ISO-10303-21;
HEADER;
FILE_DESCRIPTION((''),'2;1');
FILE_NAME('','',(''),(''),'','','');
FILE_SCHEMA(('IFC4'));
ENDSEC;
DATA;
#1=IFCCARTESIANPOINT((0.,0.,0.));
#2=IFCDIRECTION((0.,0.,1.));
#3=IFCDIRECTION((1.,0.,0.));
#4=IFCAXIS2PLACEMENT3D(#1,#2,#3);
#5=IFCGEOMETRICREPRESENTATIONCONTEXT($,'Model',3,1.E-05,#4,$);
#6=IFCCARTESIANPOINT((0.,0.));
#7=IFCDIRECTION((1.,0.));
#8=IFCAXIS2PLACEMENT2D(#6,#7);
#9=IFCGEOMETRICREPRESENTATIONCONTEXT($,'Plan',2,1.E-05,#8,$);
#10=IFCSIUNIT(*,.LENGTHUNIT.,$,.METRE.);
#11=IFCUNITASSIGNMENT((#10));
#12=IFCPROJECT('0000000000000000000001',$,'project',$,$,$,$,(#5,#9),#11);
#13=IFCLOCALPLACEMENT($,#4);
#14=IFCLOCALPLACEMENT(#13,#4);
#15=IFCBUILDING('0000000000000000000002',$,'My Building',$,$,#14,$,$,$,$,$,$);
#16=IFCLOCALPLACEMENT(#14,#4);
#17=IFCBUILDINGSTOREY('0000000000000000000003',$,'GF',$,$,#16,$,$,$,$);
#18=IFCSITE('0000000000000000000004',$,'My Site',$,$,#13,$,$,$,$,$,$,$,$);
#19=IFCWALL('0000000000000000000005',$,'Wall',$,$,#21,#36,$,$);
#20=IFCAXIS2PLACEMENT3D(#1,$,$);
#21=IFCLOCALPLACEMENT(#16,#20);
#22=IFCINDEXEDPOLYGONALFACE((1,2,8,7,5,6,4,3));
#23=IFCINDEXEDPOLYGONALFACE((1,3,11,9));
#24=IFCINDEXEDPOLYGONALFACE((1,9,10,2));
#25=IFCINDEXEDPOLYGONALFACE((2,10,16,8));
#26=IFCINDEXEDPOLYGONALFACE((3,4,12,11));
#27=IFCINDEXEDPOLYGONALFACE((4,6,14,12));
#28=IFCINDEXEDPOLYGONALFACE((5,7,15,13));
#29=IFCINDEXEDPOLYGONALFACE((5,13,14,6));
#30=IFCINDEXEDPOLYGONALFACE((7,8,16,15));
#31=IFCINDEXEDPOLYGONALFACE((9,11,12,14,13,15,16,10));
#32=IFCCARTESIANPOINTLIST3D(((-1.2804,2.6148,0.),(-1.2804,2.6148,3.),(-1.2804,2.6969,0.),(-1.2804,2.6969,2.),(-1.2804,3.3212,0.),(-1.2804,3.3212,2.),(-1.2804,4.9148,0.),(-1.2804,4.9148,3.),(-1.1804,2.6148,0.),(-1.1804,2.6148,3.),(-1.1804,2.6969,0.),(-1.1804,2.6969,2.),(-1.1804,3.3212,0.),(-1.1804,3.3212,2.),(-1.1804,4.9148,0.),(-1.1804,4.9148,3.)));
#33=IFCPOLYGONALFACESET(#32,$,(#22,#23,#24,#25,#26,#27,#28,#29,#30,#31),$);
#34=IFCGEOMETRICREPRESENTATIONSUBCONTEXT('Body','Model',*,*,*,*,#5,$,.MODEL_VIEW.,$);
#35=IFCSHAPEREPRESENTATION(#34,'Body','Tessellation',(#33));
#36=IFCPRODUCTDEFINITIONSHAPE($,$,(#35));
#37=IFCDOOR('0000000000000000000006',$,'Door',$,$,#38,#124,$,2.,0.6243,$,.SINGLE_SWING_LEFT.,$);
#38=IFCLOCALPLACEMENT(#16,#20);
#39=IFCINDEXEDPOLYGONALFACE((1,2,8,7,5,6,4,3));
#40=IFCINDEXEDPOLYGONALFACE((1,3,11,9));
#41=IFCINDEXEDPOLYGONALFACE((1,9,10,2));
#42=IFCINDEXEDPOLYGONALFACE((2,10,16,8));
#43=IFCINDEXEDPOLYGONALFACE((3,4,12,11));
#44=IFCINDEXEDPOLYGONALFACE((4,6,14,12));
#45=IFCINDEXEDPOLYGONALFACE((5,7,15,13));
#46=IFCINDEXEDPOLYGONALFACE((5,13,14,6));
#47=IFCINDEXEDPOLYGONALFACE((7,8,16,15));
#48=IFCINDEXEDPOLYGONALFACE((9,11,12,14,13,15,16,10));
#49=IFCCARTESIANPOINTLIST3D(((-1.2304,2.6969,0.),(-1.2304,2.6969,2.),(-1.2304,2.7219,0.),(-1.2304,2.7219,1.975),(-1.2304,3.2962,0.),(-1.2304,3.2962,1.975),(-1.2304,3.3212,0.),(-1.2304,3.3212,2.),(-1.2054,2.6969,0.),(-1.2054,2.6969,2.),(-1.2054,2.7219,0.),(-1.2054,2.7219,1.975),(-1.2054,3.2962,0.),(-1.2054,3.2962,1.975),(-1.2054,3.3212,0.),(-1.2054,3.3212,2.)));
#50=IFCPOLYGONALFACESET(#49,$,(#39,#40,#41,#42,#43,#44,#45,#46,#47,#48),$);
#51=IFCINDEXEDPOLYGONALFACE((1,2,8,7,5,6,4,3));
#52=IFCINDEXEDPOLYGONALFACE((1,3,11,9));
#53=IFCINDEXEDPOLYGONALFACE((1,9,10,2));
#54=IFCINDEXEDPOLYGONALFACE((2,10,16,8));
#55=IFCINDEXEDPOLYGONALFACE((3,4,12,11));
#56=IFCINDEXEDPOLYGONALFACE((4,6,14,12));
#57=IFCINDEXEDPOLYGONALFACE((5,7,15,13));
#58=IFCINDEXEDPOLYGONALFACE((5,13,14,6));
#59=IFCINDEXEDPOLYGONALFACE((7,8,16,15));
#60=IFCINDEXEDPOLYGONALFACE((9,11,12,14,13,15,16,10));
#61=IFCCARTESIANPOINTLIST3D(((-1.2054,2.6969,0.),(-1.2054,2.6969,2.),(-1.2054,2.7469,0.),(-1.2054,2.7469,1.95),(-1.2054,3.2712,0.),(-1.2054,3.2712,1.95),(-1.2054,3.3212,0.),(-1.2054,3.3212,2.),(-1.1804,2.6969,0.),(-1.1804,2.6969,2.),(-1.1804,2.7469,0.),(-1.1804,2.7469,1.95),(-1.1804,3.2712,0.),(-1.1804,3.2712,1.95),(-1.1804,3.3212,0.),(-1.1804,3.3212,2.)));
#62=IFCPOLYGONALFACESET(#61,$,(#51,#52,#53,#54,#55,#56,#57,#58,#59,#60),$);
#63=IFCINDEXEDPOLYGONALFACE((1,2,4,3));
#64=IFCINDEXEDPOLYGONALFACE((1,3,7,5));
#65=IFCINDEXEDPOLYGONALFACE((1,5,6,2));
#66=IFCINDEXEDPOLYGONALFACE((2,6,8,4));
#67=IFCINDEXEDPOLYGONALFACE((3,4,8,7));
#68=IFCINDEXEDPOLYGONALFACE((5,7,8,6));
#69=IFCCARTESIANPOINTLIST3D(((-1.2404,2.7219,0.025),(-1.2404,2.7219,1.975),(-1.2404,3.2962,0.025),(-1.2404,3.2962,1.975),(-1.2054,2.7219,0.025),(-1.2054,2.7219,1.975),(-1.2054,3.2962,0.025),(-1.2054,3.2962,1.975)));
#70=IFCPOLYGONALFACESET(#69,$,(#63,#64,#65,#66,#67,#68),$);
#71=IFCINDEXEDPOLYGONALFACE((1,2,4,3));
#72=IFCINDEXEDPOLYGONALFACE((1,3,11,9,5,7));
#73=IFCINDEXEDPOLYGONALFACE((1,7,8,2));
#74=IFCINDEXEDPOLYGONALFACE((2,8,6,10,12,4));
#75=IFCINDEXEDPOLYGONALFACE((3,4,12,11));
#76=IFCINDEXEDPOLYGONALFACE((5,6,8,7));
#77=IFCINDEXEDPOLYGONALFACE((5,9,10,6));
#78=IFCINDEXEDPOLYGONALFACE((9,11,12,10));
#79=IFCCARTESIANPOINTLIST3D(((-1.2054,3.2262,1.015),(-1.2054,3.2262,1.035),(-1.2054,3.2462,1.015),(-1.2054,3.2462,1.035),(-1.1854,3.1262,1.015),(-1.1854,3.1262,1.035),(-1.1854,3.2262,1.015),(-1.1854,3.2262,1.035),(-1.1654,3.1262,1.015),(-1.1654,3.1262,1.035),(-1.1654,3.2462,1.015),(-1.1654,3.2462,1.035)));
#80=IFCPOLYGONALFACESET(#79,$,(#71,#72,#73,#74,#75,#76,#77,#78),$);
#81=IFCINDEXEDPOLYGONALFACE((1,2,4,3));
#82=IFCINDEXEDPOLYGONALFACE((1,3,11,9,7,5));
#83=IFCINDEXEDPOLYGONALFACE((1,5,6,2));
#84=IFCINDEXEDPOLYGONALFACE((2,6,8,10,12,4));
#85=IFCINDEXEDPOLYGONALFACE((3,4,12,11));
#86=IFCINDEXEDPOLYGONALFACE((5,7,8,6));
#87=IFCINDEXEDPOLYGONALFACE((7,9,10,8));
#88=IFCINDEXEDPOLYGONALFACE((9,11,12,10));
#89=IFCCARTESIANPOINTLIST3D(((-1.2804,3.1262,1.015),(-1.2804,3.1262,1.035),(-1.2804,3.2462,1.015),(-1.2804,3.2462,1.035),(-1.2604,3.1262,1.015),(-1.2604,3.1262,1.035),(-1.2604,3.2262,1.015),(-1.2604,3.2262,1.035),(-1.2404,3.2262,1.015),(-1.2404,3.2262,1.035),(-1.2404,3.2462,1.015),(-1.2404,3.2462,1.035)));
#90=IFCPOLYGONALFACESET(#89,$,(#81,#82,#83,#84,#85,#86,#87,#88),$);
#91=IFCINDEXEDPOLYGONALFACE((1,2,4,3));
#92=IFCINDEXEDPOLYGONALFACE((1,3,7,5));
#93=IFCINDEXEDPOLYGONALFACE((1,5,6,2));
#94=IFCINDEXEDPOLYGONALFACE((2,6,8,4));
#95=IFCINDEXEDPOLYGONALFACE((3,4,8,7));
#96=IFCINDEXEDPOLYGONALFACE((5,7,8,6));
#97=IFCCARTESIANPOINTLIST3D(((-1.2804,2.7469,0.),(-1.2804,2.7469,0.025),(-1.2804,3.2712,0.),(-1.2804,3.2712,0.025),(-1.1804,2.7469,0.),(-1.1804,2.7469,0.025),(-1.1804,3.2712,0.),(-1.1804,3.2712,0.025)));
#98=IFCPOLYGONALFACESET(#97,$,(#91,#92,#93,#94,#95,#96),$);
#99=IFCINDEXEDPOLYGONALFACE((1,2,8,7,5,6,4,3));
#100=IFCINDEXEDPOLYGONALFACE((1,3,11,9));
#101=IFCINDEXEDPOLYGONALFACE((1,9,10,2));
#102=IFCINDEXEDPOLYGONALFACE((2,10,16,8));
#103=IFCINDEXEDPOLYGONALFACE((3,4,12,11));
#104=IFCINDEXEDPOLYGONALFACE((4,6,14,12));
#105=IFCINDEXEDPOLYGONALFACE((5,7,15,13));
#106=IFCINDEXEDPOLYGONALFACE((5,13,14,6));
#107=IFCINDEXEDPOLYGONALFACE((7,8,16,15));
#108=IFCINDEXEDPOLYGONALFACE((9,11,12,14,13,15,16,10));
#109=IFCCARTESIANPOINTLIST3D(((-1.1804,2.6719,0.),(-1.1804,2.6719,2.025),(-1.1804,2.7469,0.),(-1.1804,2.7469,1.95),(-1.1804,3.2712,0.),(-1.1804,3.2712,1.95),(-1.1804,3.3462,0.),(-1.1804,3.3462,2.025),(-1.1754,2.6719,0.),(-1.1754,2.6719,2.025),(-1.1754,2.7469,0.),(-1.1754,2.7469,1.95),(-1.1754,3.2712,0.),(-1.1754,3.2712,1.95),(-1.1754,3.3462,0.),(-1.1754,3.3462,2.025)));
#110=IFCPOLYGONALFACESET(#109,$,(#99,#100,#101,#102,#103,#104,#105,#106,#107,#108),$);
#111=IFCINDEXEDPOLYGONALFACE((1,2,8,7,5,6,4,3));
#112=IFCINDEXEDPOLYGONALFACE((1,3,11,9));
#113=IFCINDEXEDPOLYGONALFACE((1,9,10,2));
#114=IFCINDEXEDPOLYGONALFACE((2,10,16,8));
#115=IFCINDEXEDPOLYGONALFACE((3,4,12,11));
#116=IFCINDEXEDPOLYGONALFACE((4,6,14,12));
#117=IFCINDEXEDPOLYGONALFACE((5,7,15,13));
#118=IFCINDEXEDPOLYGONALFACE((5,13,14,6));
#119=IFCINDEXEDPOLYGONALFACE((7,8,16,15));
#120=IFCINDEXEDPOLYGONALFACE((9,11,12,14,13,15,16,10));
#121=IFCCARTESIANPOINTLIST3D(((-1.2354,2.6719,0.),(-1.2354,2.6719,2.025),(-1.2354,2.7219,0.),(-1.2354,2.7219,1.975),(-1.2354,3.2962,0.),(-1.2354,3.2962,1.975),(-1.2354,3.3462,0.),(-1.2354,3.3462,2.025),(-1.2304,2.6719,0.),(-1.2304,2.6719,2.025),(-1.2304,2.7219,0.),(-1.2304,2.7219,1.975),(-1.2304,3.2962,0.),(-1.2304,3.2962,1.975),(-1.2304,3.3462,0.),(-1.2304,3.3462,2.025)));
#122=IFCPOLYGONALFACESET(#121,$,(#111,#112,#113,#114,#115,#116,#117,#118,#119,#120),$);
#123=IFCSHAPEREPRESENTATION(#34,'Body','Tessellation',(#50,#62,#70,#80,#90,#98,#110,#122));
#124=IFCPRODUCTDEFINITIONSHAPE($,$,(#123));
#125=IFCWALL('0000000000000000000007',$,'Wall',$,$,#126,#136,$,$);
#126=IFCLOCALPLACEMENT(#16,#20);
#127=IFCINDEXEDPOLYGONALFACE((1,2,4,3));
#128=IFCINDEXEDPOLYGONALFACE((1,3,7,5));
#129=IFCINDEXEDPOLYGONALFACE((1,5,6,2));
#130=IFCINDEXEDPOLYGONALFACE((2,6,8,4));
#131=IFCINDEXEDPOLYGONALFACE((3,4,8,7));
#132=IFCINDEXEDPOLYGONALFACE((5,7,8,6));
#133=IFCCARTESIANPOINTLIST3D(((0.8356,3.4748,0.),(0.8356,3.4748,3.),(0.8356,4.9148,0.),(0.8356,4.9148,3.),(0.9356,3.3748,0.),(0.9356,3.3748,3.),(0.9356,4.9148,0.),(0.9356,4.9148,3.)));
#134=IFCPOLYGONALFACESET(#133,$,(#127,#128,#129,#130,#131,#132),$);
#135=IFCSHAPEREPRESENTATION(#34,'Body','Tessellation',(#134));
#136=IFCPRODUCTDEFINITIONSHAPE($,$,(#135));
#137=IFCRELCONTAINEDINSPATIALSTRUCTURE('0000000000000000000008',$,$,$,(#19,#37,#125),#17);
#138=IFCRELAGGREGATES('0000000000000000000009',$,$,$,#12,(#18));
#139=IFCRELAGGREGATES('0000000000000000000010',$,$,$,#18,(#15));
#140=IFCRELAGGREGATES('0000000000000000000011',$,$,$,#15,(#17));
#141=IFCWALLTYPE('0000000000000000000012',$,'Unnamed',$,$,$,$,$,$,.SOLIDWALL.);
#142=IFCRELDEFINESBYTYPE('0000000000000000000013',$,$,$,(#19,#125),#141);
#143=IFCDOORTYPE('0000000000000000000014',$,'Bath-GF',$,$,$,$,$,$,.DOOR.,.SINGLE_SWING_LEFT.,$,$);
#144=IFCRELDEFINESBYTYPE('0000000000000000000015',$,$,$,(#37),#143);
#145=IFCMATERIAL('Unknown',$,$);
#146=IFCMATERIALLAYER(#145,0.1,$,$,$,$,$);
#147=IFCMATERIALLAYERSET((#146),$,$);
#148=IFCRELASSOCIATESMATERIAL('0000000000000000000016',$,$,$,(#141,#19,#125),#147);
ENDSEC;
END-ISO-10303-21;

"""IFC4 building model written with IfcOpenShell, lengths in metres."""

from ifc_helpers import new_model, entity, si_unit, frame, origin_with_axes, origin_2d_with_axis, place, context, subcontext, project, spatial, line, indexed_curve, outline, extrude, shape, source, transform, mapped, material, layer, layer_set, layer_usage, type_object, type_shapes, element, fill, save


model = new_model("IFC4")

# Units and contexts
model_context = context("Model", 3, precision=1e-05, world=origin_with_axes())
plan_context = context("Plan", 2, precision=1e-05, world=origin_2d_with_axis())
body_context_1 = subcontext(model_context, "Body", "Model", "MODEL_VIEW")
body_context_2 = subcontext(plan_context, "Body", "Plan", "PLAN_VIEW")
ifc_project = project(units=[si_unit("LENGTHUNIT", "METRE")], contexts=[model_context, plan_context])

# Site, building, storey
site_placement = place(None, origin_with_axes())
site = spatial("IfcSite", under=ifc_project, at=site_placement, Name="My Site")
building_placement = place(site_placement, origin_with_axes())
building = spatial("IfcBuilding", under=site, at=building_placement, Name="My Building")
storey_placement = place(building_placement, origin_with_axes())
storey = spatial("IfcBuildingStorey", under=building, at=storey_placement, Name="GF")

# Shared definitions
ifc_material = material(Name="Unknown")

# Shared definitions
ifc_layer_1 = layer(ifc_material, 0.1)
ifc_layer_set_1 = layer_set([ifc_layer_1])
wall_type = type_object("IfcWallType", Name="Unnamed", PredefinedType="SOLIDWALL", material=ifc_layer_set_1)

# Wall, opening, door
ifc_layer_usage_1 = layer_usage(ifc_layer_set_1, "AXIS2", "POSITIVE", 0.0)
wall_1_placement = place(storey_placement, frame((-1.1804, 2.6148, 0.0), z_axis=(0.0, 0.0, 1.0), x_axis=(0.0, 1.0, 0.0)))
wall_1 = element("IfcWall", 1, at=wall_1_placement, inside=storey, type_object=wall_type, material=ifc_layer_usage_1, Name="Wall", context=body_context_1, shape_type="SweptSolid", body=[
    extrude(outline(indexed_curve([(0.0, 0.0), (0.0, 0.1), (2.3, 0.1), (2.3, 0.0)], segments=[line(1, 2, 3, 4, 1)])), origin_with_axes(), (0.0, 0.0, 1.0), 3.0),
])
shared_shape_1 = source(origin_with_axes(), body_context_1, "Body", "SweptSolid", [
    extrude(outline(indexed_curve([(0.0, 0.0), (0.6243, 0.0), (0.6243, 2.0), (0.0, 2.0)], segments=[line(1, 2, 3, 4, 1)])), frame((0.0, -0.6, 0.0), z_axis=(0.0, -1.0, 0.0), x_axis=(1.0, 0.0, 0.0)), (0.0, 0.0, -1.0), 1.2),
])
opening_1_placement = place(wall_1_placement, frame((0.082, 0.0, 0.0), z_axis=(0.0, 0.0, 1.0), x_axis=(1.0, 0.0, 0.0)))
opening_1 = element("IfcOpeningElement", 2, at=opening_1_placement, cuts=wall_1, PredefinedType="OPENING", context=body_context_1, shape_type="MappedRepresentation", body=[
    mapped(shared_shape_1, transform((0.0, 0.0, 0.0), x_axis=(1.0, 0.0, 0.0), y_axis=(0.0, 1.0, 0.0), z_axis=(0.0, 0.0, 1.0), scale=1.0)),
])
door_type_1 = type_object("IfcDoorType", Name="Bath-GF", OperationType="SINGLE_SWING_LEFT", PredefinedType="DOOR")
shared_shape_2 = source(origin_with_axes(), body_context_1, "Body", "SweptSolid", [
    extrude(outline(indexed_curve([(0.0, 0.0), (0.0, 2.0), (0.6243, 2.0), (0.6243, 0.0), (0.5993, 0.0), (0.5993, 1.975), (0.025, 1.975), (0.025, 0.0)], segments=[line(1, 2, 3, 4, 5, 6, 7, 8, 1)])), frame((0.0, 0.025, 0.0), z_axis=(0.0, -1.0, 0.0), x_axis=(1.0, 0.0, 0.0)), (0.0, 0.0, -1.0), 0.025),
    extrude(outline(indexed_curve([(0.0, 0.0), (0.0, 2.0), (0.6243, 2.0), (0.6243, 0.0), (0.5743, 0.0), (0.5743, 1.95), (0.05, 1.95), (0.05, 0.0)], segments=[line(1, 2, 3, 4, 5, 6, 7, 8, 1)])), frame((0.0, 0.0, 0.0), z_axis=(0.0, -1.0, 0.0), x_axis=(1.0, 0.0, 0.0)), (0.0, 0.0, -1.0), 0.025),
    extrude(outline(indexed_curve([(0.0, 0.0), (0.5743, 0.0), (0.5743, 0.035), (0.0, 0.035)], segments=[line(1, 2, 3, 4, 1)])), frame((0.025, 0.025, 0.025), z_axis=(0.0, 0.0, 1.0), x_axis=(1.0, 0.0, 0.0)), (0.0, 0.0, 1.0), 1.95),
    extrude(outline(indexed_curve([(0.0, 0.0), (0.0, -0.04), (-0.12, -0.04), (-0.12, -0.02), (-0.02, -0.02), (-0.02, 0.0)], segments=[line(1, 2, 3, 4, 5, 6, 1)])), frame((0.5493, 0.025, 1.015), z_axis=(0.0, 0.0, 1.0), x_axis=(1.0, 0.0, 0.0)), (0.0, 0.0, 1.0), 0.02),
    extrude(outline(indexed_curve([(0.0, 0.0), (0.0, 0.04), (-0.12, 0.04), (-0.12, 0.02), (-0.02, 0.02), (-0.02, 0.0)], segments=[line(1, 2, 3, 4, 5, 6, 1)])), frame((0.5493, 0.06, 1.015), z_axis=(0.0, 0.0, 1.0), x_axis=(1.0, 0.0, 0.0)), (0.0, 0.0, 1.0), 0.02),
    extrude(outline(indexed_curve([(0.0, 0.0), (0.5243, 0.0), (0.5243, 0.1), (0.0, 0.1)], segments=[line(1, 2, 3, 4, 1)])), frame((0.05, 0.0, 0.0), z_axis=(0.0, 0.0, 1.0), x_axis=(1.0, 0.0, 0.0)), (0.0, 0.0, 1.0), 0.025),
    extrude(outline(indexed_curve([(0.0, 0.0), (0.0, 2.025), (0.6743, 2.025), (0.6743, 0.0), (0.5993, 0.0), (0.5993, 1.95), (0.075, 1.95), (0.075, 0.0)], segments=[line(1, 2, 3, 4, 5, 6, 7, 8, 1)])), frame((-0.025, -0.005, 0.0), z_axis=(0.0, -1.0, 0.0), x_axis=(1.0, 0.0, 0.0)), (0.0, 0.0, -1.0), 0.005),
    extrude(outline(indexed_curve([(0.0, 0.0), (0.0, 2.025), (0.6743, 2.025), (0.6743, 0.0), (0.6243, 0.0), (0.6243, 1.975), (0.05, 1.975), (0.05, 0.0)], segments=[line(1, 2, 3, 4, 5, 6, 7, 8, 1)])), frame((-0.025, 0.05, 0.0), z_axis=(0.0, -1.0, 0.0), x_axis=(1.0, 0.0, 0.0)), (0.0, 0.0, -1.0), 0.005),
])
shared_shape_3 = source(origin_with_axes(), body_context_2, "Body", "Curve2D", [
    entity("IfcIndexedPolyCurve", entity("IfcCartesianPointList2D", [[0.0, 0.0], [0.0, 0.05], [0.025, 0.05], [0.025, 0.025], [0.05, 0.025], [0.05, 0.0]]), [entity("IfcLineIndex", [1, 2, 3, 4, 5, 6, 1])]),
    entity("IfcIndexedPolyCurve", entity("IfcCartesianPointList2D", [[0.6243, 0.0], [0.6243, 0.05], [0.5993, 0.05], [0.5993, 0.025], [0.5743, 0.025], [0.5743, 0.0]]), [entity("IfcLineIndex", [1, 2, 3, 4, 5, 6, 1])]),
    entity("IfcTrimmedCurve", entity("IfcEllipse", entity("IfcAxis2Placement2D", entity("IfcCartesianPoint", [0.06, 0.05]), entity("IfcDirection", [1.0, 0.0])), 0.5393, 0.5743), [entity("IfcCartesianPoint", [0.5993, 0.05])], [entity("IfcCartesianPoint", [0.06, 0.6243])], True, "CARTESIAN"),
    entity("IfcIndexedPolyCurve", entity("IfcCartesianPointList2D", [[0.025, 0.05], [0.06, 0.05], [0.06, 0.6243], [0.025, 0.6243]]), [entity("IfcLineIndex", [1, 2, 3, 4, 1])]),
])
type_shapes(door_type_1, [shared_shape_2, shared_shape_3])
door_1_placement = place(opening_1_placement, frame((0.0, 0.0, 0.0), z_axis=(0.0, 0.0, 1.0), x_axis=(1.0, 0.0, 0.0)))
door_1 = element("IfcDoor", 3, at=door_1_placement, inside=storey, type_object=door_type_1, Name="Door", OperationType="SINGLE_SWING_LEFT", OverallHeight=2.0, OverallWidth=0.6243, shapes=[
    shape(body_context_1, "Body", "MappedRepresentation", [mapped(shared_shape_2, transform((0.0, 0.0, 0.0), x_axis=(1.0, 0.0, 0.0), y_axis=(0.0, 1.0, 0.0), z_axis=(0.0, 0.0, 1.0), scale=1.0))]),
    shape(body_context_2, "Body", "MappedRepresentation", [mapped(shared_shape_3, transform((0.0, 0.0, 0.0), x_axis=(1.0, 0.0, 0.0), y_axis=(0.0, 1.0, 0.0), z_axis=(0.0, 0.0, 1.0), scale=1.0))]),
])
fill(opening_1, door_1)

# Wall
ifc_layer_usage_2 = layer_usage(ifc_layer_set_1, "AXIS2", "POSITIVE", 0.0)
wall_2_placement = place(storey_placement, frame((0.8356, 4.9148, 0.0), z_axis=(0.0, 0.0, 1.0), x_axis=(0.0, -1.0, 0.0)))
element("IfcWall", 4, at=wall_2_placement, inside=storey, type_object=wall_type, material=ifc_layer_usage_2, Name="Wall", context=body_context_1, shape_type="SweptSolid", body=[
    extrude(outline(indexed_curve([(0.0, 0.0), (0.0, 0.1), (1.54, 0.1), (1.44, 0.0)], segments=[line(1, 2, 3, 4, 1)])), origin_with_axes(), (0.0, 0.0, 1.0), 3.0),
])

save(model, "model.ifc")
